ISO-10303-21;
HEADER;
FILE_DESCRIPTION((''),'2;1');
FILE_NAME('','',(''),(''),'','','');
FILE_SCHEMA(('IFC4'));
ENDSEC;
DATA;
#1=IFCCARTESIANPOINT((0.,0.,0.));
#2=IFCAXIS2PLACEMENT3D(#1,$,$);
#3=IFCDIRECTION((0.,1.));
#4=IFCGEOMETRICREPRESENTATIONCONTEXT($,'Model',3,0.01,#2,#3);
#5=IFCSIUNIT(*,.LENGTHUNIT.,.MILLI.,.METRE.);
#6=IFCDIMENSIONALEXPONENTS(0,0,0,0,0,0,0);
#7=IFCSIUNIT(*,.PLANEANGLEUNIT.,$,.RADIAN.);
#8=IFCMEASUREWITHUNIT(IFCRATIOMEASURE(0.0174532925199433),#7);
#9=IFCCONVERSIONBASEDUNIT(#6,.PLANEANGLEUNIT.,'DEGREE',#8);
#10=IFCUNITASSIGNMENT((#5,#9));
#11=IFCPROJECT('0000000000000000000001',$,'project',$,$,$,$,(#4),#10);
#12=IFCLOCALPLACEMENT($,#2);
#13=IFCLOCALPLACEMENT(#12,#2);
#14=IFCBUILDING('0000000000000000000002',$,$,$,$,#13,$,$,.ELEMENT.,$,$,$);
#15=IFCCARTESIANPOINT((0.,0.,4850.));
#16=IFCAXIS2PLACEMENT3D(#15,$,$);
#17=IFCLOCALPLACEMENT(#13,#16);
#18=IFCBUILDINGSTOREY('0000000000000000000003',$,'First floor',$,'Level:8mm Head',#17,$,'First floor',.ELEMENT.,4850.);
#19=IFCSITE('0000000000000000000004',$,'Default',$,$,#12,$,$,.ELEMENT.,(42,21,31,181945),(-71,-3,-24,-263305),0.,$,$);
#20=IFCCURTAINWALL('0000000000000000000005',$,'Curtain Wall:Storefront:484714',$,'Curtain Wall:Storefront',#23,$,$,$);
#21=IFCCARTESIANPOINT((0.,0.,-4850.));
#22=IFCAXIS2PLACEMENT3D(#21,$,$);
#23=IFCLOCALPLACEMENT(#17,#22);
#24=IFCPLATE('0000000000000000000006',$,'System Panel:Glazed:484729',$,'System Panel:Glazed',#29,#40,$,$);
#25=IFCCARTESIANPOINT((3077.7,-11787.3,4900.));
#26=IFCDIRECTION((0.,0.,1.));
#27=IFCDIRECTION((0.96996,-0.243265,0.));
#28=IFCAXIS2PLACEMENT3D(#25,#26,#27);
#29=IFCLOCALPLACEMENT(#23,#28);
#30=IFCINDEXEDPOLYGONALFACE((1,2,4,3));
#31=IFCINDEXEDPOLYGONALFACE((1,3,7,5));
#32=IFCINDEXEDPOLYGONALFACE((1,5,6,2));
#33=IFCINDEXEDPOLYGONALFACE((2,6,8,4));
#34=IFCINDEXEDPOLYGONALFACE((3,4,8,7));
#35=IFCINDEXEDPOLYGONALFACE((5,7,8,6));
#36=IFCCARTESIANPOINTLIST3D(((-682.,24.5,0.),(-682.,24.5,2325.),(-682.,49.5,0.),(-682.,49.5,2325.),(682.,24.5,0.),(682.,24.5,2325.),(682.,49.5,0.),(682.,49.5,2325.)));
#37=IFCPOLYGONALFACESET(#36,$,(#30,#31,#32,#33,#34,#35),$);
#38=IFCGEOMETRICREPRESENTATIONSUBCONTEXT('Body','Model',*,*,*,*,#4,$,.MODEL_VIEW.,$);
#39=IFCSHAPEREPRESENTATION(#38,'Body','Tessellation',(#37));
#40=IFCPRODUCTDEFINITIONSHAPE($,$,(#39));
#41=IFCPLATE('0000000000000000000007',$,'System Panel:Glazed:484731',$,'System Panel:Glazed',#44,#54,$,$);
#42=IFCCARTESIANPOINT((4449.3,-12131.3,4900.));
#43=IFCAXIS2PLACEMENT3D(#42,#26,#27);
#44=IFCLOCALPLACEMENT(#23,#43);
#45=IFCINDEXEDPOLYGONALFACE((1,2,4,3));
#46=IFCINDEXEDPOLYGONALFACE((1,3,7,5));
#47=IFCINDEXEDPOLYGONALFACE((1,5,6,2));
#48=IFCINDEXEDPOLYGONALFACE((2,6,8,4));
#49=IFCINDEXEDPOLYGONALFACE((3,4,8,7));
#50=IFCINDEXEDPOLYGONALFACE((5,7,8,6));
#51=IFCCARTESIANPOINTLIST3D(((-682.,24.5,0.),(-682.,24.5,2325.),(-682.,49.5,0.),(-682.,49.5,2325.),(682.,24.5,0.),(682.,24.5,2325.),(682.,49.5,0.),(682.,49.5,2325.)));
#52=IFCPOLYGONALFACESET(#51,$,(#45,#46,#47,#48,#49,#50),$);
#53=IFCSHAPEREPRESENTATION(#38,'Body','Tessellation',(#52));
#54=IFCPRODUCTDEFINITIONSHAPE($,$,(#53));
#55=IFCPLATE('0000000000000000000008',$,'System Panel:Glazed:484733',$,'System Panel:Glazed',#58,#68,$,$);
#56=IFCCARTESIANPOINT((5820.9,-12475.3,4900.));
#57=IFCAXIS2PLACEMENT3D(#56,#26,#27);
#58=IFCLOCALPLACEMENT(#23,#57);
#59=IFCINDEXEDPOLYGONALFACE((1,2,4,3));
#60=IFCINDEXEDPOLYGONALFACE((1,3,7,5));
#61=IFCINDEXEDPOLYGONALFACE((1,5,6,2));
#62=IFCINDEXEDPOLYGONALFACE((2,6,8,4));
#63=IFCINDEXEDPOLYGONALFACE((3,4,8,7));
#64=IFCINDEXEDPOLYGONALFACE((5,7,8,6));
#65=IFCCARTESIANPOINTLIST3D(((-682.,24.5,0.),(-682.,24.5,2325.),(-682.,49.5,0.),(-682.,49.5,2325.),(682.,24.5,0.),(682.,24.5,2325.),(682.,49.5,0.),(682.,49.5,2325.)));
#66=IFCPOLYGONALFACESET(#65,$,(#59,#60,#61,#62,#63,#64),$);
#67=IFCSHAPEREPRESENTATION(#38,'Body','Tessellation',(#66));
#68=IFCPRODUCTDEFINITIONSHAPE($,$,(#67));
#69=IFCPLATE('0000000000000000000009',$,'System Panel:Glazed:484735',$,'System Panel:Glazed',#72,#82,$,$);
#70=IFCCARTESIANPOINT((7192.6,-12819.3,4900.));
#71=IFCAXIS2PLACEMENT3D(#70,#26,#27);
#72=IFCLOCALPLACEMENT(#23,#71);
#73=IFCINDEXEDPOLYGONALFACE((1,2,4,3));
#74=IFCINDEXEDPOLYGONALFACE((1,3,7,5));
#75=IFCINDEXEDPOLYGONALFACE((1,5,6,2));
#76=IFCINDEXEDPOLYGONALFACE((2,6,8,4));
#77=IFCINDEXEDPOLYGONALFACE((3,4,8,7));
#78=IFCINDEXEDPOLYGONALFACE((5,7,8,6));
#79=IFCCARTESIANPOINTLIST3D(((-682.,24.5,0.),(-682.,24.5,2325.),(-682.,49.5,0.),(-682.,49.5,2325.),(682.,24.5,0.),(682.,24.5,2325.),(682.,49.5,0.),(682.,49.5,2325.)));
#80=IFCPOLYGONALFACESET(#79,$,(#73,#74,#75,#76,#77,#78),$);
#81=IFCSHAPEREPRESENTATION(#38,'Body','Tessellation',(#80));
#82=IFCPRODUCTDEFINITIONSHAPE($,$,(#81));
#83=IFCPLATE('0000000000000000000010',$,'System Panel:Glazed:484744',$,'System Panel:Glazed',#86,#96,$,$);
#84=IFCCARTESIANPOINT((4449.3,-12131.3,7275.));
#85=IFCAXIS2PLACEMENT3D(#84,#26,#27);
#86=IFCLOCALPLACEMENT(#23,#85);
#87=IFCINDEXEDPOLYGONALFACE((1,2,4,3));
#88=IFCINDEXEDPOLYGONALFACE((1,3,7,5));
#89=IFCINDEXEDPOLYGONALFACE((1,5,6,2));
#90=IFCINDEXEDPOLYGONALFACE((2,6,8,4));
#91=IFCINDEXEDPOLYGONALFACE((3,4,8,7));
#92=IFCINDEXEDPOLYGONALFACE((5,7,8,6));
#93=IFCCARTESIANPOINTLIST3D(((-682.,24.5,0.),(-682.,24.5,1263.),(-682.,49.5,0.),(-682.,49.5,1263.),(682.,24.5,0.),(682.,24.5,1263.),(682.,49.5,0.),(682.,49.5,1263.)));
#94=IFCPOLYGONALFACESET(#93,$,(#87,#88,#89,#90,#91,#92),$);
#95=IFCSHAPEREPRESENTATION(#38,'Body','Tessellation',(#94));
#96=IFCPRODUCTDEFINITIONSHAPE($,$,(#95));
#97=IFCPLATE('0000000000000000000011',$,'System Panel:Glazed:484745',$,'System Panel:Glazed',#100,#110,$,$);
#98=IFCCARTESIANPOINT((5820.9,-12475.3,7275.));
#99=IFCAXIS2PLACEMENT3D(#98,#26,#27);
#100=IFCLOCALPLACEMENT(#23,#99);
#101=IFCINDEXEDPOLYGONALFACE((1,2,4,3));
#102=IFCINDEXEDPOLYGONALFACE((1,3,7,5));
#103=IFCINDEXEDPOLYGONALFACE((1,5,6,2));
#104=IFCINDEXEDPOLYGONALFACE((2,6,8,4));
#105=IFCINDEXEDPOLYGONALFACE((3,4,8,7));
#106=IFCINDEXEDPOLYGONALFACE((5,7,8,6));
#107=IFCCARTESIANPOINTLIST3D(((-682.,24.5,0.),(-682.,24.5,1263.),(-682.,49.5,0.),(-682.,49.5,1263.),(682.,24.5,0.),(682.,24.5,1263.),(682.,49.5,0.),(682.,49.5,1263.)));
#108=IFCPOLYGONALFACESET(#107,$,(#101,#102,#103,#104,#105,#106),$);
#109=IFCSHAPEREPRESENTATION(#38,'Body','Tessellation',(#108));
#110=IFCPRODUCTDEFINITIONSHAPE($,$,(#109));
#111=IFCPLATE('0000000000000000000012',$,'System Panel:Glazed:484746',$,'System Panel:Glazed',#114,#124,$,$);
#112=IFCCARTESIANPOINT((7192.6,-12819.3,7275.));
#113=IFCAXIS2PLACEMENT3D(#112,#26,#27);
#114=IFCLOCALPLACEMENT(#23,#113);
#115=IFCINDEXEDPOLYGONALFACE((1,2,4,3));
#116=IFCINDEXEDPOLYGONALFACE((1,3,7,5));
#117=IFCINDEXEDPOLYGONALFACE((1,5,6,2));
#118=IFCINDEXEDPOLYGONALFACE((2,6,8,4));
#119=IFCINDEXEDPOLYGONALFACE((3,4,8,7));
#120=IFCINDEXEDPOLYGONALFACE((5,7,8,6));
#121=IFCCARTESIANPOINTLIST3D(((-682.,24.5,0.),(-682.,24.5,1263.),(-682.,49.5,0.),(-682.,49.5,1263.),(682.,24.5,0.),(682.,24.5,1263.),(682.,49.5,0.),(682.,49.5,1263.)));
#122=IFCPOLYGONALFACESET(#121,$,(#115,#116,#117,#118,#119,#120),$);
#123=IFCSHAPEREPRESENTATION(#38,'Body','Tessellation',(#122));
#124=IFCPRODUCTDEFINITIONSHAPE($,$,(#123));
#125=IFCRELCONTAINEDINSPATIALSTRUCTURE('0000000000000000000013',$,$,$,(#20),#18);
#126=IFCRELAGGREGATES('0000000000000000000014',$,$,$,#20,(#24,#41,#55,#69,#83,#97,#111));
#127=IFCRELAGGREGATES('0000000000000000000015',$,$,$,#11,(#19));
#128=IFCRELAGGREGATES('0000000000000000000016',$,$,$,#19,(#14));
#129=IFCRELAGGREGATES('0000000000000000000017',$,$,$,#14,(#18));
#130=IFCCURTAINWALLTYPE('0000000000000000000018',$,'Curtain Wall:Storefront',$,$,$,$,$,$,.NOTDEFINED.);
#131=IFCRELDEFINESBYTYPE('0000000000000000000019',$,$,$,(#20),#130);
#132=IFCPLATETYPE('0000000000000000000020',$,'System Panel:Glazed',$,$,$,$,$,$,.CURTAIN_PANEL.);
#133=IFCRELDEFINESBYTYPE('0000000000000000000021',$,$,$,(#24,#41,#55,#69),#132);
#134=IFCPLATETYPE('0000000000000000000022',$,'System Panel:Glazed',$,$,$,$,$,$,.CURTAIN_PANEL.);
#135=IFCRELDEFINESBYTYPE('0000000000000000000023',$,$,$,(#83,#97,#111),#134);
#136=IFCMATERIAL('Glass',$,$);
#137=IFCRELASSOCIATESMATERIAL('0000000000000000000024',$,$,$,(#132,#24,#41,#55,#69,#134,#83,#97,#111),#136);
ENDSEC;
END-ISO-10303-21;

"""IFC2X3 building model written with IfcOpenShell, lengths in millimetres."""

from ifc_helpers import new_model, entity, si_unit, converted_unit, direction, frame, origin, origin_2d_with_axis, place, context, subcontext, project, spatial, rectangle, extrude, source, transform, mapped, material, type_object, type_shapes, element, aggregate, save


model = new_model("IFC2X3")

# Units and contexts
model_context = context("Model", 3, precision=0.01, world=origin(), true_north=direction((0.0, 1.0)))
body_context = subcontext(model_context, "Body", "Model", "MODEL_VIEW")
ifc_project = project(units=[si_unit("LENGTHUNIT", "METRE", prefix="MILLI"), converted_unit("PLANEANGLEUNIT", "DEGREE", entity("IfcRatioMeasure", 0.0174532925199433), si_unit("PLANEANGLEUNIT", "RADIAN"), dimensions=[0, 0, 0, 0, 0, 0, 0])], contexts=[model_context])

# Site, building, storey
site_placement = place(None, origin())
site = spatial("IfcSite", under=ifc_project, at=site_placement, Name="Default", CompositionType="ELEMENT", RefLatitude=(42, 21, 31, 181945), RefLongitude=(-71, -3, -24, -263305), RefElevation=0.0)
building_placement = place(site_placement, origin())
building = spatial("IfcBuilding", under=site, at=building_placement, CompositionType="ELEMENT")
storey_placement = place(building_placement, frame((0.0, 0.0, 4850.0)))
storey = spatial("IfcBuildingStorey", under=building, at=storey_placement, Name="First floor", ObjectType="Level:8mm Head", LongName="First floor", CompositionType="ELEMENT", Elevation=4850.0)

# Curtain wall, plates
curtain_wall_type = type_object("IfcCurtainWallType", Name="Curtain Wall:Storefront", PredefinedType="NOTDEFINED")
curtain_wall_placement = place(storey_placement, frame((0.0, 0.0, -4850.0)))
curtain_wall = element("IfcCurtainWall", 1, at=curtain_wall_placement, inside=storey, type_object=curtain_wall_type, Name="Curtain Wall:Storefront:484714", ObjectType="Curtain Wall:Storefront")
ifc_material_1 = material(Name="Glass")
plate_type_1 = type_object("IfcPlateType", Name="System Panel:Glazed", PredefinedType="CURTAIN_PANEL", material=ifc_material_1)
shared_shape_1 = source(origin(), body_context, "Body", "SweptSolid", [
    extrude(rectangle(XDim=25.0, YDim=1364.1, at=origin_2d_with_axis()), frame((0.0, 37.0, 0.0), z_axis=(0.0, 0.0, 1.0), x_axis=(0.0, 1.0, 0.0)), (0.0, 0.0, 1.0), 2325.0),
])
type_shapes(plate_type_1, [shared_shape_1])
plate_1_placement = place(curtain_wall_placement, frame((3077.7, -11787.3, 4900.0), z_axis=(0.0, 0.0, 1.0), x_axis=(0.96996, -0.243265, 0.0)))
plate_1 = element("IfcPlate", 2, at=plate_1_placement, type_object=plate_type_1, material=ifc_material_1, Name="System Panel:Glazed:484729", ObjectType="System Panel:Glazed", context=body_context, shape_type="MappedRepresentation", body=[
    mapped(shared_shape_1, transform((0.0, 0.0, 0.0), scale=1.0)),
])
plate_2_placement = place(curtain_wall_placement, frame((4449.3, -12131.3, 4900.0), z_axis=(0.0, 0.0, 1.0), x_axis=(0.96996, -0.243265, 0.0)))
plate_2 = element("IfcPlate", 3, at=plate_2_placement, type_object=plate_type_1, material=ifc_material_1, Name="System Panel:Glazed:484731", ObjectType="System Panel:Glazed", context=body_context, shape_type="MappedRepresentation", body=[
    mapped(shared_shape_1, transform((0.0, 0.0, 0.0), scale=1.0)),
])
plate_3_placement = place(curtain_wall_placement, frame((5820.9, -12475.3, 4900.0), z_axis=(0.0, 0.0, 1.0), x_axis=(0.96996, -0.243265, 0.0)))
plate_3 = element("IfcPlate", 4, at=plate_3_placement, type_object=plate_type_1, material=ifc_material_1, Name="System Panel:Glazed:484733", ObjectType="System Panel:Glazed", context=body_context, shape_type="MappedRepresentation", body=[
    mapped(shared_shape_1, transform((0.0, 0.0, 0.0), scale=1.0)),
])
plate_4_placement = place(curtain_wall_placement, frame((7192.6, -12819.3, 4900.0), z_axis=(0.0, 0.0, 1.0), x_axis=(0.96996, -0.243265, 0.0)))
plate_4 = element("IfcPlate", 5, at=plate_4_placement, type_object=plate_type_1, material=ifc_material_1, Name="System Panel:Glazed:484735", ObjectType="System Panel:Glazed", context=body_context, shape_type="MappedRepresentation", body=[
    mapped(shared_shape_1, transform((0.0, 0.0, 0.0), scale=1.0)),
])
plate_type_2 = type_object("IfcPlateType", Name="System Panel:Glazed", PredefinedType="CURTAIN_PANEL", material=ifc_material_1)
shared_shape_2 = source(origin(), body_context, "Body", "SweptSolid", [
    extrude(rectangle(XDim=25.0, YDim=1364.1, at=origin_2d_with_axis()), frame((0.0, 37.0, 0.0), z_axis=(0.0, 0.0, 1.0), x_axis=(0.0, 1.0, 0.0)), (0.0, 0.0, 1.0), 1263.0),
])
type_shapes(plate_type_2, [shared_shape_2])
plate_5_placement = place(curtain_wall_placement, frame((4449.3, -12131.3, 7275.0), z_axis=(0.0, 0.0, 1.0), x_axis=(0.96996, -0.243265, 0.0)))
plate_5 = element("IfcPlate", 6, at=plate_5_placement, type_object=plate_type_2, material=ifc_material_1, Name="System Panel:Glazed:484744", ObjectType="System Panel:Glazed", context=body_context, shape_type="MappedRepresentation", body=[
    mapped(shared_shape_2, transform((0.0, 0.0, 0.0), scale=1.0)),
])
plate_6_placement = place(curtain_wall_placement, frame((5820.9, -12475.3, 7275.0), z_axis=(0.0, 0.0, 1.0), x_axis=(0.96996, -0.243265, 0.0)))
plate_6 = element("IfcPlate", 7, at=plate_6_placement, type_object=plate_type_2, material=ifc_material_1, Name="System Panel:Glazed:484745", ObjectType="System Panel:Glazed", context=body_context, shape_type="MappedRepresentation", body=[
    mapped(shared_shape_2, transform((0.0, 0.0, 0.0), scale=1.0)),
])
plate_7_placement = place(curtain_wall_placement, frame((7192.6, -12819.3, 7275.0), z_axis=(0.0, 0.0, 1.0), x_axis=(0.96996, -0.243265, 0.0)))
plate_7 = element("IfcPlate", 8, at=plate_7_placement, type_object=plate_type_2, material=ifc_material_1, Name="System Panel:Glazed:484746", ObjectType="System Panel:Glazed", context=body_context, shape_type="MappedRepresentation", body=[
    mapped(shared_shape_2, transform((0.0, 0.0, 0.0), scale=1.0)),
])
aggregate(curtain_wall, [plate_1, plate_2, plate_3, plate_4, plate_5, plate_6, plate_7])

save(model, "model.ifc")
